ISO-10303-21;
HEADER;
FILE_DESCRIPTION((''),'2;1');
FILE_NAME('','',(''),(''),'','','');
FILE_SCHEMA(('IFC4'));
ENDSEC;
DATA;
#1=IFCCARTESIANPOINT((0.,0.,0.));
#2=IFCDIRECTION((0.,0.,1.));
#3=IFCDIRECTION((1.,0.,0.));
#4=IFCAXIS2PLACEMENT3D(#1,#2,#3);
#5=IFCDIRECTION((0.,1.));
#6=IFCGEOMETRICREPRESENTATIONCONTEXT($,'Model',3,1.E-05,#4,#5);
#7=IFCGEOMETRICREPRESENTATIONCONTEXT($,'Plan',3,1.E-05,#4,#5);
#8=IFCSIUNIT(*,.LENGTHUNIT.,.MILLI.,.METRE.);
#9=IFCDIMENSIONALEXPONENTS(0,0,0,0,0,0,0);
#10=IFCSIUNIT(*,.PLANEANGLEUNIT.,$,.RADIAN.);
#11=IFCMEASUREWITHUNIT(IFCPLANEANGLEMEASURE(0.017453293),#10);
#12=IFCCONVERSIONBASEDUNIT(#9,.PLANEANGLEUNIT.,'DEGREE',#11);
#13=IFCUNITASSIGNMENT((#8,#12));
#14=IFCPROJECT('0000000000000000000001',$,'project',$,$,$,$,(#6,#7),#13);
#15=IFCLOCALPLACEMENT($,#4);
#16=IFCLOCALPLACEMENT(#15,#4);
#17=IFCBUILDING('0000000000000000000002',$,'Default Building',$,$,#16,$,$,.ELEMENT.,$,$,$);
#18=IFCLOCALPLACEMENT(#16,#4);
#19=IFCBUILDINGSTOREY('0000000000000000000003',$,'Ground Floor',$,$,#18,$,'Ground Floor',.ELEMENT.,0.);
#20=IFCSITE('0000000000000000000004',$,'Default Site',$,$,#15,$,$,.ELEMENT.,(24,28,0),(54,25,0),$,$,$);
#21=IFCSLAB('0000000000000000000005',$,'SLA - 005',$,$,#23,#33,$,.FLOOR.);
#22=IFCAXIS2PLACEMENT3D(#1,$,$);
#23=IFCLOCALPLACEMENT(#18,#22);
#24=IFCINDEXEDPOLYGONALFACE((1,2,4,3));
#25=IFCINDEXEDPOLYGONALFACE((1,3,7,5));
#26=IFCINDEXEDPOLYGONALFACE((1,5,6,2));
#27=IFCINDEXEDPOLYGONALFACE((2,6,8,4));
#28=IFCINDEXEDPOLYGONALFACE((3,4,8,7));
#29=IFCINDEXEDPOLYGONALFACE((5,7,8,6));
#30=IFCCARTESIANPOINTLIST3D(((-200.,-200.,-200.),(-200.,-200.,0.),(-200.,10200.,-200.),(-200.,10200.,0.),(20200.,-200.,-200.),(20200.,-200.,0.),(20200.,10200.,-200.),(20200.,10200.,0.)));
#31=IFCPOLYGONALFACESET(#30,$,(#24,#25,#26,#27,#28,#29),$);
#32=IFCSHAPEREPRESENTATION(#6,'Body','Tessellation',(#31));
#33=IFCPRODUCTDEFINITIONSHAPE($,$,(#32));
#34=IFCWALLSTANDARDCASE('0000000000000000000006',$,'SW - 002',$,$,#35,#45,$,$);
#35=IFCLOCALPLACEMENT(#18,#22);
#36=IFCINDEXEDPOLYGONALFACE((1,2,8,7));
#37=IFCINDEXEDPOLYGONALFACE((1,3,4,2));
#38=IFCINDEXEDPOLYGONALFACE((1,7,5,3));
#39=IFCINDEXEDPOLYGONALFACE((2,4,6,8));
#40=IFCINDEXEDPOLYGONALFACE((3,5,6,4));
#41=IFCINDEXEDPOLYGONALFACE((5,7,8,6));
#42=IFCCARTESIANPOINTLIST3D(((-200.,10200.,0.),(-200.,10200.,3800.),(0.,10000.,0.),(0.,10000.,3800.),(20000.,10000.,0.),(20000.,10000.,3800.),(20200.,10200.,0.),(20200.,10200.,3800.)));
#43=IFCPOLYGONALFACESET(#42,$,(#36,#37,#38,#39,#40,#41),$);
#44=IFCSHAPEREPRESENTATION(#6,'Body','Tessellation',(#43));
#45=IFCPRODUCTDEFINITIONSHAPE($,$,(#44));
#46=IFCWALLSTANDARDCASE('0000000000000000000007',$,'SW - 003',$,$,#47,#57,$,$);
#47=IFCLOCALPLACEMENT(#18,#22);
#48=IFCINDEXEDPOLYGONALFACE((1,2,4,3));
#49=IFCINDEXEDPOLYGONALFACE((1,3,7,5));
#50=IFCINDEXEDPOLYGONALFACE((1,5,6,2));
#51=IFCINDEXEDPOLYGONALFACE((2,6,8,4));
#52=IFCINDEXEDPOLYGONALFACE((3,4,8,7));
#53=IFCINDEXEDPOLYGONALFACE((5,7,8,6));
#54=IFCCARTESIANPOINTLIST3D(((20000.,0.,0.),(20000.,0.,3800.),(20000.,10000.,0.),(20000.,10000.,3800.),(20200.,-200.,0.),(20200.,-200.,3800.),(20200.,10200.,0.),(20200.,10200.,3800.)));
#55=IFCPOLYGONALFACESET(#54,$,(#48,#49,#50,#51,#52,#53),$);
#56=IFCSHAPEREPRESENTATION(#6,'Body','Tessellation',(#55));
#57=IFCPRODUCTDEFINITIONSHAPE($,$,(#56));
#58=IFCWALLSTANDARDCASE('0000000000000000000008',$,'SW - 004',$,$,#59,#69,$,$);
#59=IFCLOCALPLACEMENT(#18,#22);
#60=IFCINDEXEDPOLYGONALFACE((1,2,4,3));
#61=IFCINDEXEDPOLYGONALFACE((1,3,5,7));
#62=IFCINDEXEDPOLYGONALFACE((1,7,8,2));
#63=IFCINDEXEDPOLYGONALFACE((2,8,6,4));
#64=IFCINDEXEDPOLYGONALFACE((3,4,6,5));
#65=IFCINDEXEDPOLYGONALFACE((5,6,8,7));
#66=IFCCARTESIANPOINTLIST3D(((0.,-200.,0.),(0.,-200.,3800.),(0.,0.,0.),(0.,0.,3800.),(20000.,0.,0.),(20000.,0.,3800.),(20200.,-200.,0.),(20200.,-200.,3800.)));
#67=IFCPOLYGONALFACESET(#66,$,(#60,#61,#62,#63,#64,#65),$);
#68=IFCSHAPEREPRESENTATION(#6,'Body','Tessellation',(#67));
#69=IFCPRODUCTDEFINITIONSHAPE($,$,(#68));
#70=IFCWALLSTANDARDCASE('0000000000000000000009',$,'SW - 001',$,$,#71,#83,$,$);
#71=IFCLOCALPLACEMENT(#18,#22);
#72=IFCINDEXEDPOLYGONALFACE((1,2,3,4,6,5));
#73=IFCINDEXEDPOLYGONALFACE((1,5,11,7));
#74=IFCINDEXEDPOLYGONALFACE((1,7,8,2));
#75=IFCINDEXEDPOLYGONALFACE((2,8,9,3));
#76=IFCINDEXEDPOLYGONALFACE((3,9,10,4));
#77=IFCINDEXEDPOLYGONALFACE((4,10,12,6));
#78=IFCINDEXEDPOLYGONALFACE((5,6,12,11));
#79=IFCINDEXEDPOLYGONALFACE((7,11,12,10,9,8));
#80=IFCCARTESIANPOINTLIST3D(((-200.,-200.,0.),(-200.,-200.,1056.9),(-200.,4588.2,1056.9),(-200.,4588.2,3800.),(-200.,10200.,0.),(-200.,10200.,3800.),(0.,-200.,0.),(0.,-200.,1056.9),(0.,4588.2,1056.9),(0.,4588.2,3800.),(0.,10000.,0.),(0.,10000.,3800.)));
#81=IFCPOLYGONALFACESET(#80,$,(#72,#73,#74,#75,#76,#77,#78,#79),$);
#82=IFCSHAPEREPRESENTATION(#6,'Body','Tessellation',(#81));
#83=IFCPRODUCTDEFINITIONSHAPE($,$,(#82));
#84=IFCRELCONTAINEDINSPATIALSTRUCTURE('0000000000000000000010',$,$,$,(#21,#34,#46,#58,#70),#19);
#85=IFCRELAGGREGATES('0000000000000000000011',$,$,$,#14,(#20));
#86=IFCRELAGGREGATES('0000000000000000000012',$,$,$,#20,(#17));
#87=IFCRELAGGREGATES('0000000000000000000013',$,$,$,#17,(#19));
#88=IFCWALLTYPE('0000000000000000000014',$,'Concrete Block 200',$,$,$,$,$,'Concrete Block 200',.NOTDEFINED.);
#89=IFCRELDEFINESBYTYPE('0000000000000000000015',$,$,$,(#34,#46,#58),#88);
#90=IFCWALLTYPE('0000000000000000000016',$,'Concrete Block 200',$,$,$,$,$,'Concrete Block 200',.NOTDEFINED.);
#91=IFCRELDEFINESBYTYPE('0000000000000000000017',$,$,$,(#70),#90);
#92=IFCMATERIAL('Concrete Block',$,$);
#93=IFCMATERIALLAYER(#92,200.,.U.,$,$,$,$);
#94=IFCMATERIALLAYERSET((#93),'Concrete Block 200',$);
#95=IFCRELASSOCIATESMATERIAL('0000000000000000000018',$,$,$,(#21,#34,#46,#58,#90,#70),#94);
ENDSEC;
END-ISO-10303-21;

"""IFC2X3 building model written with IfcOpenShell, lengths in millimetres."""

from ifc_helpers import new_model, entity, si_unit, converted_unit, direction, frame, origin_with_axes, place, context, project, spatial, polyline, outline, extrude, material, layer, layer_set, layer_usage, type_object, element, save


model = new_model("IFC2X3")

# Units and contexts
model_context = context("Model", 3, precision=1e-05, world=origin_with_axes(), true_north=direction((0.0, 1.0)))
plan_context = context("Plan", 3, precision=1e-05, world=origin_with_axes(), true_north=direction((0.0, 1.0)))
ifc_project = project(units=[si_unit("LENGTHUNIT", "METRE", prefix="MILLI"), converted_unit("PLANEANGLEUNIT", "DEGREE", entity("IfcPlaneAngleMeasure", 0.017453293), si_unit("PLANEANGLEUNIT", "RADIAN"), dimensions=[0, 0, 0, 0, 0, 0, 0])], contexts=[model_context, plan_context])

# Site, building, storey
site_placement = place(None, origin_with_axes())
site = spatial("IfcSite", under=ifc_project, at=site_placement, Name="Default Site", CompositionType="ELEMENT", RefLatitude=(24, 28, 0), RefLongitude=(54, 25, 0))
building_placement = place(site_placement, origin_with_axes())
building = spatial("IfcBuilding", under=site, at=building_placement, Name="Default Building", CompositionType="ELEMENT")
storey_placement = place(building_placement, origin_with_axes())
storey = spatial("IfcBuildingStorey", under=building, at=storey_placement, Name="Ground Floor", LongName="Ground Floor", CompositionType="ELEMENT", Elevation=0.0)

# Slab
ifc_material = material(Name="Concrete Block")
ifc_layer = layer(ifc_material, 200.0, ventilated="UNKNOWN")
ifc_layer_set = layer_set([ifc_layer], Name="Concrete Block 200")
ifc_layer_usage_1 = layer_usage(ifc_layer_set, "AXIS3", "NEGATIVE", 200.0)
slab_placement = place(storey_placement, frame((-200.0, 10200.0, -200.0), z_axis=(0.0, 0.0, 1.0), x_axis=(1.0, 0.0, 0.0)))
element("IfcSlab", 1, at=slab_placement, inside=storey, material=ifc_layer_usage_1, Name="SLA - 005", PredefinedType="FLOOR", context=model_context, shape_type="SweptSolid", body=[
    extrude(outline(polyline([(0.0, 0.0), (20400.0, 0.0), (20400.0, -10400.0), (0.0, -10400.0), (0.0, 0.0)])), origin_with_axes(), (0.0, 0.0, 1.0), 200.0),
])

# Walls
ifc_layer_usage_2 = layer_usage(ifc_layer_set, "AXIS2", "POSITIVE", 0.0)
wall_type_1 = type_object("IfcWallType", Name="Concrete Block 200", ElementType="Concrete Block 200", PredefinedType="NOTDEFINED")
wall_1_placement = place(storey_placement, frame((0.0, 10000.0, 0.0), z_axis=(0.0, 0.0, 1.0), x_axis=(1.0, 0.0, 0.0)))
element("IfcWallStandardCase", 2, at=wall_1_placement, inside=storey, type_object=wall_type_1, material=ifc_layer_usage_2, Name="SW - 002", context=model_context, shape_type="SweptSolid", body=[
    extrude(outline(polyline([(0.0, 0.0), (20000.0, 0.0), (20200.0, 200.0), (-200.0, 200.0), (0.0, 0.0)])), origin_with_axes(), (0.0, 0.0, 1.0), 3800.0),
])
ifc_layer_usage_3 = layer_usage(ifc_layer_set, "AXIS2", "POSITIVE", 0.0)
wall_2_placement = place(storey_placement, frame((20000.0, 10000.0, 0.0), z_axis=(0.0, 0.0, 1.0), x_axis=(0.0, -1.0, 0.0)))
element("IfcWallStandardCase", 3, at=wall_2_placement, inside=storey, type_object=wall_type_1, material=ifc_layer_usage_3, Name="SW - 003", context=model_context, shape_type="SweptSolid", body=[
    extrude(outline(polyline([(0.0, 0.0), (10000.0, 0.0), (10200.0, 200.0), (-200.0, 200.0), (0.0, 0.0)])), origin_with_axes(), (0.0, 0.0, 1.0), 3800.0),
])
ifc_layer_usage_4 = layer_usage(ifc_layer_set, "AXIS2", "POSITIVE", 0.0)
wall_3_placement = place(storey_placement, frame((20000.0, 0.0, 0.0), z_axis=(0.0, 0.0, 1.0), x_axis=(-1.0, 0.0, 0.0)))
element("IfcWallStandardCase", 4, at=wall_3_placement, inside=storey, type_object=wall_type_1, material=ifc_layer_usage_4, Name="SW - 004", context=model_context, shape_type="SweptSolid", body=[
    extrude(outline(polyline([(0.0, 0.0), (20000.0, 0.0), (20000.0, 200.0), (-200.0, 200.0), (0.0, 0.0)])), origin_with_axes(), (0.0, 0.0, 1.0), 3800.0),
])

# Wall, opening
ifc_layer_usage_5 = layer_usage(ifc_layer_set, "AXIS2", "POSITIVE", 0.0)
wall_type_2 = type_object("IfcWallType", Name="Concrete Block 200", ElementType="Concrete Block 200", PredefinedType="NOTDEFINED", material=ifc_layer_set)
wall_4_placement = place(storey_placement, frame((0.0, -200.0, 0.0), z_axis=(0.0, 0.0, 1.0), x_axis=(0.0, 1.0, 0.0)))
wall_4 = element("IfcWallStandardCase", 5, at=wall_4_placement, inside=storey, type_object=wall_type_2, material=ifc_layer_usage_5, Name="SW - 001", context=model_context, shape_type="SweptSolid", body=[
    extrude(outline(polyline([(0.0, 0.0), (10200.0, 0.0), (10400.0, 200.0), (0.0, 200.0), (0.0, 0.0)])), origin_with_axes(), (0.0, 0.0, 1.0), 3800.0),
])
opening_placement = place(wall_4_placement, frame((2394.1, 0.0, 1056.9), z_axis=(0.0, 0.0, 1.0), x_axis=(1.0, 0.0, 0.0)))
element("IfcOpeningElement", 6, at=opening_placement, cuts=wall_4, ObjectType="Opening", context=model_context, shape_type="SweptSolid", body=[
    extrude(outline(polyline([(-2394.1, 0.0), (2394.1, 0.0), (2394.1, 2743.2), (-2394.1, 2743.2), (-2394.1, 0.0)])), frame((0.0, 0.0, 0.0), z_axis=(0.0, 1.0, 0.0), x_axis=(-1.0, 0.0, 0.0)), (0.0, 0.0, 1.0), 200.0),
])

save(model, "model.ifc")
